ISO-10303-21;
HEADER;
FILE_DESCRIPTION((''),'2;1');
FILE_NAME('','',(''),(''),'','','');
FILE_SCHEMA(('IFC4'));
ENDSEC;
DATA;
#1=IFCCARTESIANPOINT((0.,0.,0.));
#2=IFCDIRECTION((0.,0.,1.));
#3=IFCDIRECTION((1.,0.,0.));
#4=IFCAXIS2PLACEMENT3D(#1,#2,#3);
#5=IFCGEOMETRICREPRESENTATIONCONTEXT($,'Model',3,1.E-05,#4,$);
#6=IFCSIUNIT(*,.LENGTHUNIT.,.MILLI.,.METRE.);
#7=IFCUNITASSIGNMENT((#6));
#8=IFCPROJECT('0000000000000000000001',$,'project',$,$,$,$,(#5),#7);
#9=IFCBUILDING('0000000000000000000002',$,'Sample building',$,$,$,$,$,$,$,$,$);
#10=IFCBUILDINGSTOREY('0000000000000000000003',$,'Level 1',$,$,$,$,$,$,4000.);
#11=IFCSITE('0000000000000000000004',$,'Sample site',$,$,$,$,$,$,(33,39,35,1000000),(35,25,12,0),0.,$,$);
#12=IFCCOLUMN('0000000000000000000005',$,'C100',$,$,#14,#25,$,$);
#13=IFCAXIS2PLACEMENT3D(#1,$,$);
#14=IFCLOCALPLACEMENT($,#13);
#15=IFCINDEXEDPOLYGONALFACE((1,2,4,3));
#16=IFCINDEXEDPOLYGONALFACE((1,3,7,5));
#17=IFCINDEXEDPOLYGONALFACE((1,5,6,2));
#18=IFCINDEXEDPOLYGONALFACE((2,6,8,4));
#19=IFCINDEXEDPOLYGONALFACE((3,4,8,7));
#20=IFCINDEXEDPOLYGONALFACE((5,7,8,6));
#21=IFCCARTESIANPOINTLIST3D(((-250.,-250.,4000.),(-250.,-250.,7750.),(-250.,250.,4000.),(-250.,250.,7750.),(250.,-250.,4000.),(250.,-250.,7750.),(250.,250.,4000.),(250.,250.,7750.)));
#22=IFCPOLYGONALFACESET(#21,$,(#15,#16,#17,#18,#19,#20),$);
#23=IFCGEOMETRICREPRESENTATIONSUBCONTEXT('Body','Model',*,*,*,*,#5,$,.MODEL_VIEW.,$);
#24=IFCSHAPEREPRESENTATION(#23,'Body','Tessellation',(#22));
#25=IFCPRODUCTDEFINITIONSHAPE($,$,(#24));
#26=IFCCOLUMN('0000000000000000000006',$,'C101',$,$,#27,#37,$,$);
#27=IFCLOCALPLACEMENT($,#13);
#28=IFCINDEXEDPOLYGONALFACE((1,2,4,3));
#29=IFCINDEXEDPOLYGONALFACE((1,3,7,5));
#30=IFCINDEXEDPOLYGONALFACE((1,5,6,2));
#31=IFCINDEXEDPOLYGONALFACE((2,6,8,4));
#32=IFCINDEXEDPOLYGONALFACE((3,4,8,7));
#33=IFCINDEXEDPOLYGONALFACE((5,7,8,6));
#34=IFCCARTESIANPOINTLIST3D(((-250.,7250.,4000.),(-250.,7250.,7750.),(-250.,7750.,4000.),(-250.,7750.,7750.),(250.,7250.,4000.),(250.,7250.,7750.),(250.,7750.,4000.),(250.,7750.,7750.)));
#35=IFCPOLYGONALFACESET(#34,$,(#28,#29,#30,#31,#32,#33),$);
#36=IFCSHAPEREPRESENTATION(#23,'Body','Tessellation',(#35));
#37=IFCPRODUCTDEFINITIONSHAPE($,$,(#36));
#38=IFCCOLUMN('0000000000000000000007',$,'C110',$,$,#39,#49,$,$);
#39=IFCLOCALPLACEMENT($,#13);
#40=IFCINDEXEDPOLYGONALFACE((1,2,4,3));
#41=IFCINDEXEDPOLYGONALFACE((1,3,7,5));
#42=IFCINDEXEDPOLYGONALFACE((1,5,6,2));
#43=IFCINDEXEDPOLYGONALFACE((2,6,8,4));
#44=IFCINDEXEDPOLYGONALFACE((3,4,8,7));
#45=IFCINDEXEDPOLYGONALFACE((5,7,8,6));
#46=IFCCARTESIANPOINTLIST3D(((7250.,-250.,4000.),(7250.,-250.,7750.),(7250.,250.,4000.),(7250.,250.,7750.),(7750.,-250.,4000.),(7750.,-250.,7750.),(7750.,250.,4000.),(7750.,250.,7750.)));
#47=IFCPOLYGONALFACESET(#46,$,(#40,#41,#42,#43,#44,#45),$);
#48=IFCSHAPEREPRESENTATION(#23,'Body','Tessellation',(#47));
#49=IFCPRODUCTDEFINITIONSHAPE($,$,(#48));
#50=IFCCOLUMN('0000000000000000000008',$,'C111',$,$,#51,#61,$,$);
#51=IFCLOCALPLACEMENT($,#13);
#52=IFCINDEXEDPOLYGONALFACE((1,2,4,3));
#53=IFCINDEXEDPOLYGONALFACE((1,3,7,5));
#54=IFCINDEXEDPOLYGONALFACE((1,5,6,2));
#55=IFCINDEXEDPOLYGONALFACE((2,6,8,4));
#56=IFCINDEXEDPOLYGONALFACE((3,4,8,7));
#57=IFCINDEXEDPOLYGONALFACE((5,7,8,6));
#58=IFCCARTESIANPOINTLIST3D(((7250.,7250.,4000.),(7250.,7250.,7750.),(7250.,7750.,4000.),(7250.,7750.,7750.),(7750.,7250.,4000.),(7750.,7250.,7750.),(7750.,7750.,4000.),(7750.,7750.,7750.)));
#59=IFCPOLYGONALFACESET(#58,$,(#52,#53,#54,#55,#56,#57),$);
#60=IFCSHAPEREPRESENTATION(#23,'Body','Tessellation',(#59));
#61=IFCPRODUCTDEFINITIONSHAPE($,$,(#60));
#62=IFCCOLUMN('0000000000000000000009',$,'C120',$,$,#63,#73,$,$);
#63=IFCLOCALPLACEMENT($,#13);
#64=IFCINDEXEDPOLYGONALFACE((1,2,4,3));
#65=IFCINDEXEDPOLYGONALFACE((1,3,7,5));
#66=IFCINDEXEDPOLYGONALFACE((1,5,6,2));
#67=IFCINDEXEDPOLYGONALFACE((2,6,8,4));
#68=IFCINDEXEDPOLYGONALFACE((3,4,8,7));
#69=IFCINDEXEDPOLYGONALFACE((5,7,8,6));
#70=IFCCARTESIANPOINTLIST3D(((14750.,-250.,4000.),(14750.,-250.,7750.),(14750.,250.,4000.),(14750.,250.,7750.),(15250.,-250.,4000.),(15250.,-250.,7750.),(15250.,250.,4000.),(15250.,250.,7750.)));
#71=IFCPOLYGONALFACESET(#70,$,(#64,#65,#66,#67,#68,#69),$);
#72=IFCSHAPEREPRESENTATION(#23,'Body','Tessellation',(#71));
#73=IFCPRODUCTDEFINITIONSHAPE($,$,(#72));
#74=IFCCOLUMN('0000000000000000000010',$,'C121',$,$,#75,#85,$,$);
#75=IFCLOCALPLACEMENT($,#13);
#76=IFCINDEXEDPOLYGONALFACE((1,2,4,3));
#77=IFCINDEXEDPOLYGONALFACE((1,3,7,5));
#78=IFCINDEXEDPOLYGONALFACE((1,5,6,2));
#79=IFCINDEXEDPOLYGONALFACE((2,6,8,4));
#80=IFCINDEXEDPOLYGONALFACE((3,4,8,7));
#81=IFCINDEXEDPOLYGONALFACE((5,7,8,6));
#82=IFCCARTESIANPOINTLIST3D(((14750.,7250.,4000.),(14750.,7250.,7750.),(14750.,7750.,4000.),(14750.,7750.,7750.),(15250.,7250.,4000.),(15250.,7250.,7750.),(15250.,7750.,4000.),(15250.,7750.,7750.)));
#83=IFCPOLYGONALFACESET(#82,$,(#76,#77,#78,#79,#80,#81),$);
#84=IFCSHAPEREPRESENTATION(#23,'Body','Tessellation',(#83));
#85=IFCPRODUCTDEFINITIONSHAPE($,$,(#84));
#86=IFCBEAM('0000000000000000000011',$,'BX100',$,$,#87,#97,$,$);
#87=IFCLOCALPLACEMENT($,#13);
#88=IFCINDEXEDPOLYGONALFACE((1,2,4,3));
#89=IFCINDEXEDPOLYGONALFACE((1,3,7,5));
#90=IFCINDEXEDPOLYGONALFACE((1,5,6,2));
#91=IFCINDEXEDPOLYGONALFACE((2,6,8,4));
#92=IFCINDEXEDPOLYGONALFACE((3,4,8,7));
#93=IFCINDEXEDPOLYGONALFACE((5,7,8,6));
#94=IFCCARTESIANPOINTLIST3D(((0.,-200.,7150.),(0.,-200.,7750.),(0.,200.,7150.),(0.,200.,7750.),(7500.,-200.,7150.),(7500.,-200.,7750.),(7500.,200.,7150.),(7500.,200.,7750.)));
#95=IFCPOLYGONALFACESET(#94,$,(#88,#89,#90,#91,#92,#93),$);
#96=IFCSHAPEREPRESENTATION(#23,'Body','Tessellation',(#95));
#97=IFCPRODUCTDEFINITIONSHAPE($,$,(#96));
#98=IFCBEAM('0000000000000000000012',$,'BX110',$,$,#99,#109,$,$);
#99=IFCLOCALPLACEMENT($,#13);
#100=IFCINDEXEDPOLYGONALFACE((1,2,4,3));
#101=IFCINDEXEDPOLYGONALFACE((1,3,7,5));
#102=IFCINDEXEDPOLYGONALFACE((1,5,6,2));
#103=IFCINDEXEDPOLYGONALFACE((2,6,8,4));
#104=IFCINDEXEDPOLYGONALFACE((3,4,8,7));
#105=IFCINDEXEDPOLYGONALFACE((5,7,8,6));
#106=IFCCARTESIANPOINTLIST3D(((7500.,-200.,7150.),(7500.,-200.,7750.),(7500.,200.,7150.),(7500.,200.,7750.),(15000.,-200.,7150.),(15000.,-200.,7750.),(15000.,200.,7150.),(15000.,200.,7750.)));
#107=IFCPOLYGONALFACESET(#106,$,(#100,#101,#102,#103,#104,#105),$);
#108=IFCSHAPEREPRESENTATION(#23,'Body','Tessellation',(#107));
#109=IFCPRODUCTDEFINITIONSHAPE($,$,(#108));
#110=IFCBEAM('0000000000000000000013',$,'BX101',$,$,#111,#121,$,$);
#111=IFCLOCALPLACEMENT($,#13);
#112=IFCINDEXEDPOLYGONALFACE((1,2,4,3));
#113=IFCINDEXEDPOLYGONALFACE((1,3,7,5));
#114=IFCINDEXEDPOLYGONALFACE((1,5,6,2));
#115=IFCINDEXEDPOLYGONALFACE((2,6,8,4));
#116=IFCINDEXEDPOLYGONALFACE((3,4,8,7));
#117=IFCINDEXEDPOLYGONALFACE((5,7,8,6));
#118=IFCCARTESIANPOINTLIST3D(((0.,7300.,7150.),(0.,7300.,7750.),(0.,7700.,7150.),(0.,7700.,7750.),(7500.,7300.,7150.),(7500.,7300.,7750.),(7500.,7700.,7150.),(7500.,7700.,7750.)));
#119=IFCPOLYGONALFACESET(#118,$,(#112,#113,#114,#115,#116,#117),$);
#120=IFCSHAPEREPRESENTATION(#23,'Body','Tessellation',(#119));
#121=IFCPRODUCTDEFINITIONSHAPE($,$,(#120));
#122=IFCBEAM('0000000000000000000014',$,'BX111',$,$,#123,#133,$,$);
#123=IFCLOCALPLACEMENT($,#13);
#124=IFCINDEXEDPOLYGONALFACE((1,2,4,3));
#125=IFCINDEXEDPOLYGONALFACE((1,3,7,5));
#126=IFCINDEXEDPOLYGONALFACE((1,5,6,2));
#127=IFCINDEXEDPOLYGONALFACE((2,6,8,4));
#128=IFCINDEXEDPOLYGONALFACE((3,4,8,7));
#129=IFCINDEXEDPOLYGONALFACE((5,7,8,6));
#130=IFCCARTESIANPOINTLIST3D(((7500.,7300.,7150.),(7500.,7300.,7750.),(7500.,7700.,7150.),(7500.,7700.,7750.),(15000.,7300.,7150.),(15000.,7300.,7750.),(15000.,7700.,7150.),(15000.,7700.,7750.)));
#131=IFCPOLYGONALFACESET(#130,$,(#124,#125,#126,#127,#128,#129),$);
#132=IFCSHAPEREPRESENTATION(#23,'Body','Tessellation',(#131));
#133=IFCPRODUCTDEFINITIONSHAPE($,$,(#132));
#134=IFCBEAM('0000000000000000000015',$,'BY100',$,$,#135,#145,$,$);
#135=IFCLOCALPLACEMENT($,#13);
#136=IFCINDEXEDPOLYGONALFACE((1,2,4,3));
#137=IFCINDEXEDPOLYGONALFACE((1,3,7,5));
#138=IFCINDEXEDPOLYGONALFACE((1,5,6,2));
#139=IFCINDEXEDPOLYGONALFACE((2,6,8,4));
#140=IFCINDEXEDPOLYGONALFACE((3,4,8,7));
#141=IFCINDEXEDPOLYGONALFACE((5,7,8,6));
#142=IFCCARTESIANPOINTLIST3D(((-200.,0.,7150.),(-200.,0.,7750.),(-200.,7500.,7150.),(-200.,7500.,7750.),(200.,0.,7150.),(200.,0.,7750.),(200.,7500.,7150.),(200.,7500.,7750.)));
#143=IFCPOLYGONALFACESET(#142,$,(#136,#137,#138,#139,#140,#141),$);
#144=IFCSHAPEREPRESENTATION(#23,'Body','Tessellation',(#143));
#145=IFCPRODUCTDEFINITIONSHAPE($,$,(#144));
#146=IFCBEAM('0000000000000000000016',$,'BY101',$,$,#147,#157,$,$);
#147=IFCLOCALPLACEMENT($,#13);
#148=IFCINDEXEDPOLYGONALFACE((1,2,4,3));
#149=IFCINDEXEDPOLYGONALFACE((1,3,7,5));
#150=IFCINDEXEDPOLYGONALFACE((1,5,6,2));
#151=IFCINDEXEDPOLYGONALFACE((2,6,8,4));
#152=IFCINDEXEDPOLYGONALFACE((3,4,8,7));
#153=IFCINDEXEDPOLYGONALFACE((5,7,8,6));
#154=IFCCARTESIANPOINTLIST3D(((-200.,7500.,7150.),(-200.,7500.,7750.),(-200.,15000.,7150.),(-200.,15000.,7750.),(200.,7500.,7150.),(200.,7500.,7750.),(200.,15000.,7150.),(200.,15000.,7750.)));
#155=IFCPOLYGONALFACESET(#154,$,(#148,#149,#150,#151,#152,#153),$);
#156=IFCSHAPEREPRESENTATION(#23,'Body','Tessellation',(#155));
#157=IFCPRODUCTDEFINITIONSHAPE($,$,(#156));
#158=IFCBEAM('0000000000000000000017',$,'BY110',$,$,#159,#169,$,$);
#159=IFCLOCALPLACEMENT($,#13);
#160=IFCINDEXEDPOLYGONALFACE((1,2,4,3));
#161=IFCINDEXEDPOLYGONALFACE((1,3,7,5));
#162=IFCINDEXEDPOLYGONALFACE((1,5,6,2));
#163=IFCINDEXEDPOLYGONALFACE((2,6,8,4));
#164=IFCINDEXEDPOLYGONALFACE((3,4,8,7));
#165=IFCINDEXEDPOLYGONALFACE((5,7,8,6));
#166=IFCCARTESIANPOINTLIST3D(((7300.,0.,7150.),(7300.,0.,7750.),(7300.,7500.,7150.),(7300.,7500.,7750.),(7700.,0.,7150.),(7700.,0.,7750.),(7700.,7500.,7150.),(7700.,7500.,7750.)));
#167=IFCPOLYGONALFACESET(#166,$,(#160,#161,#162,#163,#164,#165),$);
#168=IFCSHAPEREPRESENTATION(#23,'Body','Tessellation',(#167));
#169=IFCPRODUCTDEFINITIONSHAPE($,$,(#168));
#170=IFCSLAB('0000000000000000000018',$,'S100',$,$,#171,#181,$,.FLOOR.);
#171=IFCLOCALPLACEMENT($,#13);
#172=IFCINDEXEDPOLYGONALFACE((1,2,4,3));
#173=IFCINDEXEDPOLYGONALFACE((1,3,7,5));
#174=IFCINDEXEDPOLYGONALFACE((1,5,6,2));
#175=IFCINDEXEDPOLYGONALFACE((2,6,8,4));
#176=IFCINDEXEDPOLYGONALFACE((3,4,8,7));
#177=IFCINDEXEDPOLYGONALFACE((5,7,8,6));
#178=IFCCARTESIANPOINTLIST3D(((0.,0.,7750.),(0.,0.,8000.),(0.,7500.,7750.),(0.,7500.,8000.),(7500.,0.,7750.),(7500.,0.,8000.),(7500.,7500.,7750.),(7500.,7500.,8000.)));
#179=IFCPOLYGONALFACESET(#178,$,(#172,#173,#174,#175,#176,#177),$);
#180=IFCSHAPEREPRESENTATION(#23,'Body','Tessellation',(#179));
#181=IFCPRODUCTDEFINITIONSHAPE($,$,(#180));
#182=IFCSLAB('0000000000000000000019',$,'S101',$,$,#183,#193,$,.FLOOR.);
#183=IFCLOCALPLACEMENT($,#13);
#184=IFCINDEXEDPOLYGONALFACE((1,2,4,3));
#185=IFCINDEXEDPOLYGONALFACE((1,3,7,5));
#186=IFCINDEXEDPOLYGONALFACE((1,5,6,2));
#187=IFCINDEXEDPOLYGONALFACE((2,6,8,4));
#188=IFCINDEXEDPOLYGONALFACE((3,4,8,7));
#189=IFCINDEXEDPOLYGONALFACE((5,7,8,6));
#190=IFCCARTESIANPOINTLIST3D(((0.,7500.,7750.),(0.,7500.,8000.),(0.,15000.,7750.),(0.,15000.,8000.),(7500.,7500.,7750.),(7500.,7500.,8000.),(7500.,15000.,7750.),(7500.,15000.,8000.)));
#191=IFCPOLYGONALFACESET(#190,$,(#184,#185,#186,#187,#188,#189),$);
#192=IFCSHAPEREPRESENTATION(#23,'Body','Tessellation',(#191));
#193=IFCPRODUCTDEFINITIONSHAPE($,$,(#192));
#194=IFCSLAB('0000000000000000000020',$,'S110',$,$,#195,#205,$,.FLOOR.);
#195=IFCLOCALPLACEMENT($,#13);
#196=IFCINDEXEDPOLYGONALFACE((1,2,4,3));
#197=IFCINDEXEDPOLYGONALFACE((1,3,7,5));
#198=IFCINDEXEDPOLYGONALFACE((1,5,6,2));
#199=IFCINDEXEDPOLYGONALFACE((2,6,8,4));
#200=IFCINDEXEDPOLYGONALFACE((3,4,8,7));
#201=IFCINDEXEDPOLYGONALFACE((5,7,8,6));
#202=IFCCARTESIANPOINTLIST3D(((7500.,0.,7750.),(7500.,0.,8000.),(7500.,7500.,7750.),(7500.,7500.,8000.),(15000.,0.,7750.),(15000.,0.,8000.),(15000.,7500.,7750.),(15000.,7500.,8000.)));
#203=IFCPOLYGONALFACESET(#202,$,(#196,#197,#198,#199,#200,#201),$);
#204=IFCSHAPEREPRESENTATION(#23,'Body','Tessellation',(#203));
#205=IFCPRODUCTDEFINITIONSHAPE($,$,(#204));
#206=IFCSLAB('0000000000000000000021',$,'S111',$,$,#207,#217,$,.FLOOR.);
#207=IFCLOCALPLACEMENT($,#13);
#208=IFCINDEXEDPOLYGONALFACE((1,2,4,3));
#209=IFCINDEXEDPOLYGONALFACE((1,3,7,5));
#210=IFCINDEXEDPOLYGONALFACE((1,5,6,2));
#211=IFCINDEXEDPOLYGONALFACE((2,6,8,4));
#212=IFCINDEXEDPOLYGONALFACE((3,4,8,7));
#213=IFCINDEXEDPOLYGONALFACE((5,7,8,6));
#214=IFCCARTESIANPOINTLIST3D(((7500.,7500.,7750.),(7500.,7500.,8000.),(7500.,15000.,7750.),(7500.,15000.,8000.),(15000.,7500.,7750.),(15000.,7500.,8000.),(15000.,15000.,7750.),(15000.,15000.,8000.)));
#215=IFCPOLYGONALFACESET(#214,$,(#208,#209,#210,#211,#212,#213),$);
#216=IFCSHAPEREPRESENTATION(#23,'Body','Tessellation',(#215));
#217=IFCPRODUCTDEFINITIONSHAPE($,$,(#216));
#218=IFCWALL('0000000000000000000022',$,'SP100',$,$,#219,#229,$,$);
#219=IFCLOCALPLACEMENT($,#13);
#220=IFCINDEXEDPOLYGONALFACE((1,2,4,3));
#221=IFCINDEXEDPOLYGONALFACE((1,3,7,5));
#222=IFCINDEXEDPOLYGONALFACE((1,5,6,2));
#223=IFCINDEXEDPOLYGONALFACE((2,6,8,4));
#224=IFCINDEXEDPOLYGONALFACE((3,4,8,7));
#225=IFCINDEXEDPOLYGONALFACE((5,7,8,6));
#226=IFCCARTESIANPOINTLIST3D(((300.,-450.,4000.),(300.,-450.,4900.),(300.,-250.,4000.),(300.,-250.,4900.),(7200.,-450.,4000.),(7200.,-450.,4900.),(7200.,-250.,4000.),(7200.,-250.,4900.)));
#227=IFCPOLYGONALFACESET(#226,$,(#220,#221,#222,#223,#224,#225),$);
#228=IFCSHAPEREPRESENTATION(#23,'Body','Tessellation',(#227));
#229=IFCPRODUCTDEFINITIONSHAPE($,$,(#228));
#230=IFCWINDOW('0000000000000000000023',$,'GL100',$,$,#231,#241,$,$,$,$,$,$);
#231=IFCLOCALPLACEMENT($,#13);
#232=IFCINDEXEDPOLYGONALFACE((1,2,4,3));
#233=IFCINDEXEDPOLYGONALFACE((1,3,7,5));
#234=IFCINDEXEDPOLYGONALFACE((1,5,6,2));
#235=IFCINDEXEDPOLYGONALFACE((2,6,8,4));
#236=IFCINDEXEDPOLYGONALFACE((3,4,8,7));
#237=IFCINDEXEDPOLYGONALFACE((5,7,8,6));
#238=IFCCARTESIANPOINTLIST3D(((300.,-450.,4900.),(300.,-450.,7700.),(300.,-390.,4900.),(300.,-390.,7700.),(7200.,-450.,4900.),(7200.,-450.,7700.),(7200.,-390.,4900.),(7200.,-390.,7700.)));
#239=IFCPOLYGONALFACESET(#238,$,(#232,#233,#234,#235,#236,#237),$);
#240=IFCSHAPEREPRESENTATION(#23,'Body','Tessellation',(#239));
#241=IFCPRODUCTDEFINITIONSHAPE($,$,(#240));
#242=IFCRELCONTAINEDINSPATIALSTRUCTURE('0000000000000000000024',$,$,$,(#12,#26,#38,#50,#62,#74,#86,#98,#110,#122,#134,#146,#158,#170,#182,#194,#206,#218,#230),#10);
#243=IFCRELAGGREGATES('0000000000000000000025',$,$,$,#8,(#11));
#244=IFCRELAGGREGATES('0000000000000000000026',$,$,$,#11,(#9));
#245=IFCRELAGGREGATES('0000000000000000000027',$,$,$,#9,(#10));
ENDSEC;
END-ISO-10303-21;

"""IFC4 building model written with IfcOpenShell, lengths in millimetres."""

from ifc_helpers import new_model, si_unit, frame, origin_with_axes, place, context, subcontext, project, spatial, indexed_curve, outline, extrude, element, save


model = new_model("IFC4")

# Units and contexts
model_context = context("Model", 3, precision=1e-05, world=origin_with_axes())
body_context = subcontext(model_context, "Body", "Model", "MODEL_VIEW")
ifc_project = project(units=[si_unit("LENGTHUNIT", "METRE", prefix="MILLI")], contexts=[model_context])

# Site, building, storey
site = spatial("IfcSite", under=ifc_project, Name="Sample site", RefLatitude=(33, 39, 35, 1000000), RefLongitude=(35, 25, 12, 0), RefElevation=0.0)
building = spatial("IfcBuilding", under=site, Name="Sample building")
storey = spatial("IfcBuildingStorey", under=building, Name="Level 1", Elevation=4000.0)

# Columns
for number, where, z_axis, x_axis, name in (
    (1, (-250.0, -250.0, 4000.0), (0.0, 0.0, 1.0), (1.0, 0.0, 0.0), "C100"),
    (2, (-250.0, 7250.0, 4000.0), (0.0, 0.0, 1.0), (1.0, 0.0, 0.0), "C101"),
    (3, (7250.0, -250.0, 4000.0), (0.0, 0.0, 1.0), (1.0, 0.0, 0.0), "C110"),
    (4, (7250.0, 7250.0, 4000.0), (0.0, 0.0, 1.0), (1.0, 0.0, 0.0), "C111"),
    (5, (14750.0, -250.0, 4000.0), (0.0, 0.0, 1.0), (1.0, 0.0, 0.0), "C120"),
    (6, (14750.0, 7250.0, 4000.0), (0.0, 0.0, 1.0), (1.0, 0.0, 0.0), "C121"),
):
    element("IfcColumn", number, at=place(None, frame(where, z_axis=z_axis, x_axis=x_axis)), inside=storey, Name=name, context=body_context, shape_type="SweptSolid", body=[
        extrude(outline(indexed_curve([(0.0, 0.0), (0.0, 500.0), (500.0, 500.0), (500.0, 0.0), (0.0, 0.0)], self_intersect=False)), origin_with_axes(), (0.0, 0.0, 1.0), 3750.0),
    ])

# Beams
for number, where, z_axis, x_axis, name in (
    (7, (0.0, -200.0, 7150.0), (0.0, 0.0, 1.0), (1.0, 0.0, 0.0), "BX100"),
    (8, (7500.0, -200.0, 7150.0), (0.0, 0.0, 1.0), (1.0, 0.0, 0.0), "BX110"),
    (9, (0.0, 7300.0, 7150.0), (0.0, 0.0, 1.0), (1.0, 0.0, 0.0), "BX101"),
    (10, (7500.0, 7300.0, 7150.0), (0.0, 0.0, 1.0), (1.0, 0.0, 0.0), "BX111"),
    (11, (200.0, 0.0, 7150.0), (0.0, 0.0, 1.0), (0.0, 1.0, 0.0), "BY100"),
    (12, (200.0, 7500.0, 7150.0), (0.0, 0.0, 1.0), (0.0, 1.0, 0.0), "BY101"),
    (13, (7700.0, 0.0, 7150.0), (0.0, 0.0, 1.0), (0.0, 1.0, 0.0), "BY110"),
):
    element("IfcBeam", number, at=place(None, frame(where, z_axis=z_axis, x_axis=x_axis)), inside=storey, Name=name, context=body_context, shape_type="SweptSolid", body=[
        extrude(outline(indexed_curve([(0.0, 0.0), (0.0, 400.0), (7500.0, 400.0), (7500.0, 0.0), (0.0, 0.0)], self_intersect=False)), origin_with_axes(), (0.0, 0.0, 1.0), 600.0),
    ])

# Slabs
for number, where, z_axis, x_axis, name in (
    (14, (0.0, 0.0, 7750.0), (0.0, 0.0, 1.0), (1.0, 0.0, 0.0), "S100"),
    (15, (0.0, 7500.0, 7750.0), (0.0, 0.0, 1.0), (1.0, 0.0, 0.0), "S101"),
    (16, (7500.0, 0.0, 7750.0), (0.0, 0.0, 1.0), (1.0, 0.0, 0.0), "S110"),
    (17, (7500.0, 7500.0, 7750.0), (0.0, 0.0, 1.0), (1.0, 0.0, 0.0), "S111"),
):
    element("IfcSlab", number, at=place(None, frame(where, z_axis=z_axis, x_axis=x_axis)), inside=storey, Name=name, PredefinedType="FLOOR", context=body_context, shape_type="SweptSolid", body=[
        extrude(outline(indexed_curve([(0.0, 0.0), (0.0, 7500.0), (7500.0, 7500.0), (7500.0, 0.0), (0.0, 0.0)], self_intersect=False)), origin_with_axes(), (0.0, 0.0, 1.0), 250.0),
    ])

# Wall
wall_1_placement = place(None, frame((300.0, -450.0, 4000.0), z_axis=(0.0, 0.0, 1.0), x_axis=(1.0, 0.0, 0.0)))
element("IfcWall", 18, at=wall_1_placement, inside=storey, Name="SP100", context=body_context, shape_type="SweptSolid", body=[
    extrude(outline(indexed_curve([(0.0, 0.0), (0.0, 200.0), (6900.0, 200.0), (6900.0, 0.0), (0.0, 0.0)], self_intersect=False)), origin_with_axes(), (0.0, 0.0, 1.0), 900.0),
])

# Window
window_1_placement = place(None, frame((300.0, -450.0, 4900.0), z_axis=(0.0, 0.0, 1.0), x_axis=(1.0, 0.0, 0.0)))
element("IfcWindow", 19, at=window_1_placement, inside=storey, Name="GL100", context=body_context, shape_type="SweptSolid", body=[
    extrude(outline(indexed_curve([(0.0, 0.0), (0.0, 60.0), (6900.0, 60.0), (6900.0, 0.0), (0.0, 0.0)], self_intersect=False)), origin_with_axes(), (0.0, 0.0, 1.0), 2800.0),
])

save(model, "model.ifc")
